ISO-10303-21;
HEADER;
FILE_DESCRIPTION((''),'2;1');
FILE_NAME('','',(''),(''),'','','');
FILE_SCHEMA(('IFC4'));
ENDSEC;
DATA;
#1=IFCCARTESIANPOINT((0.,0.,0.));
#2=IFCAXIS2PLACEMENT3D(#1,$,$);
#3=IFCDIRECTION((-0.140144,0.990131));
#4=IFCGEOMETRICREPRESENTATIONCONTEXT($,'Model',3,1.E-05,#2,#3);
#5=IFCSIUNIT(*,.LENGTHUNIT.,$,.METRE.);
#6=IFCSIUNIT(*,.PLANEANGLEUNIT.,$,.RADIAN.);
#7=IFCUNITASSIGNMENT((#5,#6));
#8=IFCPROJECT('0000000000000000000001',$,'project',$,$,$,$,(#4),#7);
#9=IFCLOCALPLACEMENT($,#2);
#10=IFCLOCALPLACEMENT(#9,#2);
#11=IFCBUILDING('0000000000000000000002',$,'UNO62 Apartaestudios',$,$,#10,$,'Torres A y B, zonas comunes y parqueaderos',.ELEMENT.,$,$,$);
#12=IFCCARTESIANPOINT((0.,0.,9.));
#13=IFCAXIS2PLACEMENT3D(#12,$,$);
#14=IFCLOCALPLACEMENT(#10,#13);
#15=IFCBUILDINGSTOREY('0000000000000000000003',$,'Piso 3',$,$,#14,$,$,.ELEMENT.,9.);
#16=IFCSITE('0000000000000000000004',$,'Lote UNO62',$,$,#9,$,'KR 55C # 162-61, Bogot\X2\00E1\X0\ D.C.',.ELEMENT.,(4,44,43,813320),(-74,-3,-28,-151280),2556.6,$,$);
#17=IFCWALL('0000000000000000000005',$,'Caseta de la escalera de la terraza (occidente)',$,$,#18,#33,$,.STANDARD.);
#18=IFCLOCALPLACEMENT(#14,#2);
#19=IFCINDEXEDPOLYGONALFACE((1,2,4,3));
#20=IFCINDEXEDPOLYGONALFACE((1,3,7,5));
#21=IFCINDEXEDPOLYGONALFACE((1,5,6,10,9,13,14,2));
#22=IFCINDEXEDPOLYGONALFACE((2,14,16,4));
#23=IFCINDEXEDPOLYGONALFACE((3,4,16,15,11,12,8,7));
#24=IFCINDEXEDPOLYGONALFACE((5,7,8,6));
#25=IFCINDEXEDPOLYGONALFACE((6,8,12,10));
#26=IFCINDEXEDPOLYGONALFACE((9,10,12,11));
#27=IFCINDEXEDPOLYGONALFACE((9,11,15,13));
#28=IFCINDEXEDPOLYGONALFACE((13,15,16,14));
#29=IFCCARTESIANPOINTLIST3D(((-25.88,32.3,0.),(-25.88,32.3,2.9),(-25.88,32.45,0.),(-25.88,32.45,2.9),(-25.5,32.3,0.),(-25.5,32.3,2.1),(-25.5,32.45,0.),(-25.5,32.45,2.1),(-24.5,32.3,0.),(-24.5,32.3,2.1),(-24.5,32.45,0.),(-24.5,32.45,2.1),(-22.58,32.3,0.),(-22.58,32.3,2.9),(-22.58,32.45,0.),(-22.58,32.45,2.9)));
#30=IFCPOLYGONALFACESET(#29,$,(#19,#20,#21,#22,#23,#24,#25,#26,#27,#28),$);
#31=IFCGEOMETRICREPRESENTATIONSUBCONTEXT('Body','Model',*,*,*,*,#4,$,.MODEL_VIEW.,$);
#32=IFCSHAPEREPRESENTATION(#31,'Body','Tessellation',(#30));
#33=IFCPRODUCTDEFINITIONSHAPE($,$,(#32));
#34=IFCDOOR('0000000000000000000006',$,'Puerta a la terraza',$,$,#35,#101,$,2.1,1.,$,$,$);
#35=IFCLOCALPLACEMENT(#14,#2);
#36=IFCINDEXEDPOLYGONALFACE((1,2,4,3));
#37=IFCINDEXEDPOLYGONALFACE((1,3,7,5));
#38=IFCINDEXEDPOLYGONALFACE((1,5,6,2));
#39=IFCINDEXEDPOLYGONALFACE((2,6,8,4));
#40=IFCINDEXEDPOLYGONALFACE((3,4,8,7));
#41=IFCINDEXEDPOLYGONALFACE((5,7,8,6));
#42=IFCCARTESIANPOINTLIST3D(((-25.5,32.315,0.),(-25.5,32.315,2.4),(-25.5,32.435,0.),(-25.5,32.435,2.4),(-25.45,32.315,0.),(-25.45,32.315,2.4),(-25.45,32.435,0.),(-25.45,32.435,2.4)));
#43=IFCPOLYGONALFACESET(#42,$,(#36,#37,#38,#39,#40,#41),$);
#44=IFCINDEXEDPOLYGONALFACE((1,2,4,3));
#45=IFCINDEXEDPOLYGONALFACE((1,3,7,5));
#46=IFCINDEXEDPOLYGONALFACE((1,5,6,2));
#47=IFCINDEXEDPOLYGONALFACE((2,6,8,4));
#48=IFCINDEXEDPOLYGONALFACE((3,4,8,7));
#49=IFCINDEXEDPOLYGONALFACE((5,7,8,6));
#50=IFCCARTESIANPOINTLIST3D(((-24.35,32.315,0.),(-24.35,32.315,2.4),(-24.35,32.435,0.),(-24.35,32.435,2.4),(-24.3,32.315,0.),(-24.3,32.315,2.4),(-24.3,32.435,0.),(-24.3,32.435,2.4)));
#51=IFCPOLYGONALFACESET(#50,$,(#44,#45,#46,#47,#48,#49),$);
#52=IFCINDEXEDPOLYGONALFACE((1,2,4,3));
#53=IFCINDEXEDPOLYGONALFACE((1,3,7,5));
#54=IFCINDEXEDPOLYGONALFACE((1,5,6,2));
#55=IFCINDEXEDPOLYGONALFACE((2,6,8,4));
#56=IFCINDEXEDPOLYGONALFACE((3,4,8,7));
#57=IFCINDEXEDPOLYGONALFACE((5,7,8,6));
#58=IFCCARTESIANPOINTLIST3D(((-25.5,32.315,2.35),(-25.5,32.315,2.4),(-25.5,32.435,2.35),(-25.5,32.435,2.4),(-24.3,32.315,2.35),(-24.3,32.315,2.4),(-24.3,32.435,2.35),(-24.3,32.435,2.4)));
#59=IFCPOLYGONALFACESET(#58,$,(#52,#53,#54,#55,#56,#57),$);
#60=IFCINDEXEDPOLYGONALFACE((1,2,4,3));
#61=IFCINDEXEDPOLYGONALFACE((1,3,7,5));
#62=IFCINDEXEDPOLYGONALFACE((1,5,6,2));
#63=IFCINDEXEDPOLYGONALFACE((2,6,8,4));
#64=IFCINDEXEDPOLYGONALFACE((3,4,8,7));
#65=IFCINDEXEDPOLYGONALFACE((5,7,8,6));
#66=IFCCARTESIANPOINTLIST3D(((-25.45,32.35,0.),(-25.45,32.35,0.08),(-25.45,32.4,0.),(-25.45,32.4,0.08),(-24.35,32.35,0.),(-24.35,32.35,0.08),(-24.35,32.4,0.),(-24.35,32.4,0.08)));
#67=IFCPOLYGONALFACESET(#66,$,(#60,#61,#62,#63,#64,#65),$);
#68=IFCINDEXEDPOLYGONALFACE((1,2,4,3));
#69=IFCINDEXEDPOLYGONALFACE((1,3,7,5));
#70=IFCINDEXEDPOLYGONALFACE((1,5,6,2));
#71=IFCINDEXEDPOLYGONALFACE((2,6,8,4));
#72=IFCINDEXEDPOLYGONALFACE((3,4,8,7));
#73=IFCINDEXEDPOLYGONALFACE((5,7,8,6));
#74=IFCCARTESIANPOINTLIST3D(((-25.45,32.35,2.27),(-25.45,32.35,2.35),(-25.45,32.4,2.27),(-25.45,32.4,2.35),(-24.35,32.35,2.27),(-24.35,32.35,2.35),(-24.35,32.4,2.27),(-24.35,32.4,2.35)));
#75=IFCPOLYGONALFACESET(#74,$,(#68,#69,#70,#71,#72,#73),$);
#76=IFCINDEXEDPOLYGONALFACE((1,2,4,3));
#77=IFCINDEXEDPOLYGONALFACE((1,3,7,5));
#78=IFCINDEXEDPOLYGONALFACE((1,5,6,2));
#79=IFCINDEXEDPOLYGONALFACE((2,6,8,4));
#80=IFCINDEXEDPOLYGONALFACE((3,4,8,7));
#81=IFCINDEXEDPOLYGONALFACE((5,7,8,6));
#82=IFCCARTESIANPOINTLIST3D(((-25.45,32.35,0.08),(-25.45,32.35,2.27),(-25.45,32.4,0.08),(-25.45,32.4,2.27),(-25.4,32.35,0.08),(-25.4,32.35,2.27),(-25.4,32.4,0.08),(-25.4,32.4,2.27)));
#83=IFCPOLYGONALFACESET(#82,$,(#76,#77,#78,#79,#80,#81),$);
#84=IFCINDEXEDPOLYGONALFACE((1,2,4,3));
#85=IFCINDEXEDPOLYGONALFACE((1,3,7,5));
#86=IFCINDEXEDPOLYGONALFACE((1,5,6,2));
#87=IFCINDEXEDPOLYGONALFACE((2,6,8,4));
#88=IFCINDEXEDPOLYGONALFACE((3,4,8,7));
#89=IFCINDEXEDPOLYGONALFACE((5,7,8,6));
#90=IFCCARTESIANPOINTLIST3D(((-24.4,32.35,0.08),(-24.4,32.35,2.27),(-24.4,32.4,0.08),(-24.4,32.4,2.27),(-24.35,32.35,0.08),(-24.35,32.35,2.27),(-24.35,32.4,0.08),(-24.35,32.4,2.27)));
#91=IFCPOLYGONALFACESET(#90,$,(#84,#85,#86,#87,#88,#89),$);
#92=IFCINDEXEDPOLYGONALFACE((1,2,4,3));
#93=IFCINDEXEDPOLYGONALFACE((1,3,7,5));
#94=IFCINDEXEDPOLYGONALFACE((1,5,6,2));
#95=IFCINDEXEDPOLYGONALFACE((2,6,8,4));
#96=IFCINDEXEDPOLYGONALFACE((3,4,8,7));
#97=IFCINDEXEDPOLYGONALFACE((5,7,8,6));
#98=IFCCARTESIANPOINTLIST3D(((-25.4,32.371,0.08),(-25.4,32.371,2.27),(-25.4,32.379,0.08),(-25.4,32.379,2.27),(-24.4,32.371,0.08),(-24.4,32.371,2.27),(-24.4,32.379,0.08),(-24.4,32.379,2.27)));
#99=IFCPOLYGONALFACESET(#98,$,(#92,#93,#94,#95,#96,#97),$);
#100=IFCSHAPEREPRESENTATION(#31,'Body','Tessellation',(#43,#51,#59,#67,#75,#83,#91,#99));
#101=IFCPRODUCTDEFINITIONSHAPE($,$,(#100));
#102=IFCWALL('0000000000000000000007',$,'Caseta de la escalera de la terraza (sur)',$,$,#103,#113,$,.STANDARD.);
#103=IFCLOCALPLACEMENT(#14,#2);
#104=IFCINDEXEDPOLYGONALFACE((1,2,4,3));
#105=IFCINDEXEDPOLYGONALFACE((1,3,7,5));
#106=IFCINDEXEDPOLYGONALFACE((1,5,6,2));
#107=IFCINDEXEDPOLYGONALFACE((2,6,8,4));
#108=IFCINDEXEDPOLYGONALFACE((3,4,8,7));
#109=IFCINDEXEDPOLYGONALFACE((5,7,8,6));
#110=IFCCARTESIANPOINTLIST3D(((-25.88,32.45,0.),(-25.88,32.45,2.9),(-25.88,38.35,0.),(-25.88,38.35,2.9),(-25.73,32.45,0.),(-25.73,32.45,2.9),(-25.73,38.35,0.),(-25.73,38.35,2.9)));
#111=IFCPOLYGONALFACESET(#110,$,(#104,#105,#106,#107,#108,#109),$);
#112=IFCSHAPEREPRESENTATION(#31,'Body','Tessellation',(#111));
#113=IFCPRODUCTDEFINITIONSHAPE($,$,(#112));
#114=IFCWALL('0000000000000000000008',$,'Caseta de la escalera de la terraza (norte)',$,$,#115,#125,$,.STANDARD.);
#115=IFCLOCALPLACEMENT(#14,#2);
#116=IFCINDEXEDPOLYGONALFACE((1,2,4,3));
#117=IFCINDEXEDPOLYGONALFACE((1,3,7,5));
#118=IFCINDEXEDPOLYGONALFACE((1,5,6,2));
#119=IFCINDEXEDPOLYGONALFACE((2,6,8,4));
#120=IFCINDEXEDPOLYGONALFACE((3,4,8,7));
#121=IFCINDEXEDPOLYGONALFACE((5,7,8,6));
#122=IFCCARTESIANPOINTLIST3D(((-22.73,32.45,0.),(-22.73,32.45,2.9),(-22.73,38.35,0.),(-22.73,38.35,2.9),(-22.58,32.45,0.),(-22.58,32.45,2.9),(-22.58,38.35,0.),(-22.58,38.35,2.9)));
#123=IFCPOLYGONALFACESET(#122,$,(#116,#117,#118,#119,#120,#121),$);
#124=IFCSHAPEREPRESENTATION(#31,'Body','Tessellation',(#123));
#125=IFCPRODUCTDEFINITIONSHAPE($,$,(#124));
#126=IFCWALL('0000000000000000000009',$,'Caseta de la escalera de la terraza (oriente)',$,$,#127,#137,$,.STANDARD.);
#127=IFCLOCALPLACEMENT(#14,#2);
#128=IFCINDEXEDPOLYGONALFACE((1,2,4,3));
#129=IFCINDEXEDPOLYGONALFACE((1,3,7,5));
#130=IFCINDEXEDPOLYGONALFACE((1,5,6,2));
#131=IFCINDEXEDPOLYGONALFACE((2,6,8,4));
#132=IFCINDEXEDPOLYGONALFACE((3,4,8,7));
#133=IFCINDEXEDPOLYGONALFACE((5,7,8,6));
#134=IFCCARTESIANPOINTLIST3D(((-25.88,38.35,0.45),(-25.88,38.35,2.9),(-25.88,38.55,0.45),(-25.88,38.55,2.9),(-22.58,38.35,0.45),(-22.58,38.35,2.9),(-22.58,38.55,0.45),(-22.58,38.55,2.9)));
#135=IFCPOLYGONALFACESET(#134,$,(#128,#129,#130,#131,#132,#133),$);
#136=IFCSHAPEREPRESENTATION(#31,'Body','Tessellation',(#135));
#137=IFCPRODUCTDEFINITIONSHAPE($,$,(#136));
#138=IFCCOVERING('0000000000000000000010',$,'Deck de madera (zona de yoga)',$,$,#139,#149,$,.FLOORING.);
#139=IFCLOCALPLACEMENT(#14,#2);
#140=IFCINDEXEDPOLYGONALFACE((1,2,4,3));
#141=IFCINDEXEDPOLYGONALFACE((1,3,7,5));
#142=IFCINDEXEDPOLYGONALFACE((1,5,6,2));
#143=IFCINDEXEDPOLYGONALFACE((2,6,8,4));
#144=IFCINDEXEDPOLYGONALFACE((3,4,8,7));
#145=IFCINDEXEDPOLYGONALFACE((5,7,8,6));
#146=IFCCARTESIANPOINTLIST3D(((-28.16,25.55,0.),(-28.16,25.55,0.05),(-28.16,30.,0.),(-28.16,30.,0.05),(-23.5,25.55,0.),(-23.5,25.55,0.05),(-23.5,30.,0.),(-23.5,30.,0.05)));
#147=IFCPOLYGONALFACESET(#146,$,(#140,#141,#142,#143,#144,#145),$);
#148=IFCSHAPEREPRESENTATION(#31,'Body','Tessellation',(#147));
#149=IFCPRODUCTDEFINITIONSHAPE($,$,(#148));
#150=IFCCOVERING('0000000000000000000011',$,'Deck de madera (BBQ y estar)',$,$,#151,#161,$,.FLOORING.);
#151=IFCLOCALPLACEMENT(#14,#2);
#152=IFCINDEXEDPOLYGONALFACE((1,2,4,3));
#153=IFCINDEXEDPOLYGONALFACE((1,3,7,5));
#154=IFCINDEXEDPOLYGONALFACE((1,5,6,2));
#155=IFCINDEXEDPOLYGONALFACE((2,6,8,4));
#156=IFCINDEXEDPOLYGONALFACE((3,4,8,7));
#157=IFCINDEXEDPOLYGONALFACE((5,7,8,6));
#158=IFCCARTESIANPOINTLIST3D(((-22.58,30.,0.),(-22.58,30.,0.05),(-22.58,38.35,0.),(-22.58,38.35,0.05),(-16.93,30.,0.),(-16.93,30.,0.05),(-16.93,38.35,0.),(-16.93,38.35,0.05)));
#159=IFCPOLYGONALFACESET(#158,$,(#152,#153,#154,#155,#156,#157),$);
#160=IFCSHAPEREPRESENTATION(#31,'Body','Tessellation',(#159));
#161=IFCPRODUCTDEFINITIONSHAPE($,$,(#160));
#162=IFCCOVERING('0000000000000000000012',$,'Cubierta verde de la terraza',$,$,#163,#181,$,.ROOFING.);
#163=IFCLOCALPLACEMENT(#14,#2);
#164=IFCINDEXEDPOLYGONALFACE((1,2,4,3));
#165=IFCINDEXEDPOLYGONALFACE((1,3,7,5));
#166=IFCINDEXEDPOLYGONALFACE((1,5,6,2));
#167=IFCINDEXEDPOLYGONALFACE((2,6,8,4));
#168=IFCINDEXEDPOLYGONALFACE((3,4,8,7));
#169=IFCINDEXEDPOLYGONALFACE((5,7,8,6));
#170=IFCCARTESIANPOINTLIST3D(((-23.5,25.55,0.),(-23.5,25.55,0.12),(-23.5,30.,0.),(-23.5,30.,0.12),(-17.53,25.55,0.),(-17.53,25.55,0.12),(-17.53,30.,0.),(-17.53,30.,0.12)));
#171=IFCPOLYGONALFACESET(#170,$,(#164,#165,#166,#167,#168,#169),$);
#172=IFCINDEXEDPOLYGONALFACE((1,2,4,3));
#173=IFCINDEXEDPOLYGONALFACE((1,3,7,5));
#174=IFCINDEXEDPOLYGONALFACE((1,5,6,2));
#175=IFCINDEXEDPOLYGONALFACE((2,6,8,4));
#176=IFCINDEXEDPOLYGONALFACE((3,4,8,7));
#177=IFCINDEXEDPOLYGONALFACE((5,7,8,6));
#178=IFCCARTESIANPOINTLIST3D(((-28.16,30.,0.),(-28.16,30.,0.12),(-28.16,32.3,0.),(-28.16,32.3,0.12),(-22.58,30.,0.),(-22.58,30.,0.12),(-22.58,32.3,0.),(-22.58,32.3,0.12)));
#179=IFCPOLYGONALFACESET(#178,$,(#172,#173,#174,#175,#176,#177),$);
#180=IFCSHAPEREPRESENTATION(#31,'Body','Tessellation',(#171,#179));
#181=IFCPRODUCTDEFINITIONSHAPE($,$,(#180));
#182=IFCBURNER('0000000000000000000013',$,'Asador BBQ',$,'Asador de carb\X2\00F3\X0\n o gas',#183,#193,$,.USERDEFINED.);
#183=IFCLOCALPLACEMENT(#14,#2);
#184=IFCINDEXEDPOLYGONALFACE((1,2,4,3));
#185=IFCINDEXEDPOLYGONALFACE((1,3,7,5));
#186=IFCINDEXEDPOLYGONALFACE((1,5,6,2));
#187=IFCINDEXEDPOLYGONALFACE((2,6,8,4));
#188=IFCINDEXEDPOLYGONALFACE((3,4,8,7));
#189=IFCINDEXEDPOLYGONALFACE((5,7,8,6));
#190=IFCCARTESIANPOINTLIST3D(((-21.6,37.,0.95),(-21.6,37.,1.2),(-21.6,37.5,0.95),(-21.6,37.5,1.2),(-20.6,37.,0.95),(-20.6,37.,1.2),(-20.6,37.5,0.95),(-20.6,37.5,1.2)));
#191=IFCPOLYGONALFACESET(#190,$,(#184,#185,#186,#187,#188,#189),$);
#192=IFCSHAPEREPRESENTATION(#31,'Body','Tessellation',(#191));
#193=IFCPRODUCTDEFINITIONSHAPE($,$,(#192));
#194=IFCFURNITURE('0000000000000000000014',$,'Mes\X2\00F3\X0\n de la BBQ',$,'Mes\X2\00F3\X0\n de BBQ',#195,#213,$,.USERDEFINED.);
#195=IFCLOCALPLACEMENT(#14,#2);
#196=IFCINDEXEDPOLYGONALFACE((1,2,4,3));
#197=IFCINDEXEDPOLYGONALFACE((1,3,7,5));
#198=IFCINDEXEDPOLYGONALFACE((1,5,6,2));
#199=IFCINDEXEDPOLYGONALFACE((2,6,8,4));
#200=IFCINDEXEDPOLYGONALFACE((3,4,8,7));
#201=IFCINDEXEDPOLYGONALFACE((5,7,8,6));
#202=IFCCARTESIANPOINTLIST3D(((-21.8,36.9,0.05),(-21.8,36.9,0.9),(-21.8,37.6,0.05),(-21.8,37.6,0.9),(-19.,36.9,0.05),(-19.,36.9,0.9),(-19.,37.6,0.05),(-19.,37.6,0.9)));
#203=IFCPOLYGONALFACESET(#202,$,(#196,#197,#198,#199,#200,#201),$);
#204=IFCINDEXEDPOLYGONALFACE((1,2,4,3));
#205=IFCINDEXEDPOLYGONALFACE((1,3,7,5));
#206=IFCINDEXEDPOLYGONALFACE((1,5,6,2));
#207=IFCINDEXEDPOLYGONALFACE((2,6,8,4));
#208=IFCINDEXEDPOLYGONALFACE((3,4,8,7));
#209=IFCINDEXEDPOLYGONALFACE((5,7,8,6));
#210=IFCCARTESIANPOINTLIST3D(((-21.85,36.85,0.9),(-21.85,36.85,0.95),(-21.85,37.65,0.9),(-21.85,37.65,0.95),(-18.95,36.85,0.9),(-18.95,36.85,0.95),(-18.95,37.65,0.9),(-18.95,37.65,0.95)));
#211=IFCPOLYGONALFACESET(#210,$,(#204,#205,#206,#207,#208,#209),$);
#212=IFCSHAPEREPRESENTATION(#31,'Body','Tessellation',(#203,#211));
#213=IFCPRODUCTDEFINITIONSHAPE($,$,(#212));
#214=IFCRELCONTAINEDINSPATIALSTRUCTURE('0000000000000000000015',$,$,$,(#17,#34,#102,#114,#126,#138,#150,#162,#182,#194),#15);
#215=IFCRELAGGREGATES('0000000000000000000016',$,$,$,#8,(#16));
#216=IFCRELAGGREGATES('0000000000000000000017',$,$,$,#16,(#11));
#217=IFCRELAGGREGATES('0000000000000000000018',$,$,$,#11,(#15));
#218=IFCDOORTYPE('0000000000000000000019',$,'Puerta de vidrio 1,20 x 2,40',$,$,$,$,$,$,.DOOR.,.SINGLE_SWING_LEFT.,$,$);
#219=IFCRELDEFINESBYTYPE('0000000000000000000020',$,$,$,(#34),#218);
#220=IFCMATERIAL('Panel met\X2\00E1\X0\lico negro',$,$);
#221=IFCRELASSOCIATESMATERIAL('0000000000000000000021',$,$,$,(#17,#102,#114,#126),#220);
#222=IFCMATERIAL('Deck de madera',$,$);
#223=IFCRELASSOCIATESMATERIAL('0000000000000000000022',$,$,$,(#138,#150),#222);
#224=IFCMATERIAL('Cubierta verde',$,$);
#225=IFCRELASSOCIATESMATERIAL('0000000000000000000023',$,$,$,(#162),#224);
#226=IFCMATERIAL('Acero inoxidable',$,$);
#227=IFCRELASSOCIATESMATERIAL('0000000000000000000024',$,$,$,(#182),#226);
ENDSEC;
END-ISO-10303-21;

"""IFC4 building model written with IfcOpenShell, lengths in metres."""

from ifc_helpers import new_model, si_unit, direction, frame, frame_2d, origin, place, context, subcontext, project, spatial, rectangle, extrude, source, transform, mapped, material, type_object, type_shapes, element, fill, save


model = new_model("IFC4")

# Units and contexts
model_context = context("Model", 3, precision=1e-05, world=origin(), true_north=direction((-0.140144, 0.990131)))
body_context = subcontext(model_context, "Body", "Model", "MODEL_VIEW")
ifc_project = project(units=[si_unit("LENGTHUNIT", "METRE"), si_unit("PLANEANGLEUNIT", "RADIAN")], contexts=[model_context])

# Site, building, storey
site_placement = place(None, origin())
site = spatial("IfcSite", under=ifc_project, at=site_placement, Name="Lote UNO62", LongName="KR 55C # 162-61, Bogotá D.C.", CompositionType="ELEMENT", RefLatitude=(4, 44, 43, 813320), RefLongitude=(-74, -3, -28, -151280), RefElevation=2556.6)
building_placement = place(site_placement, origin())
building = spatial("IfcBuilding", under=site, at=building_placement, Name="UNO62 Apartaestudios", LongName="Torres A y B, zonas comunes y parqueaderos", CompositionType="ELEMENT")
storey_placement = place(building_placement, frame((0.0, 0.0, 9.0)))
storey = spatial("IfcBuildingStorey", under=building, at=storey_placement, Name="Piso 3", CompositionType="ELEMENT", Elevation=9.0)

# Shared definitions
ifc_material_1 = material(Name="Panel metálico negro")

# Wall, opening, door
wall_1_placement = place(storey_placement, origin())
wall_1 = element("IfcWall", 1, at=wall_1_placement, inside=storey, material=ifc_material_1, Name="Caseta de la escalera de la terraza (occidente)", PredefinedType="STANDARD", context=body_context, shape_type="SweptSolid", body=[
    extrude(rectangle(XDim=3.3, YDim=0.15, at=frame_2d((-24.23, 32.375))), origin(), (0.0, 0.0, 1.0), 2.9),
])
opening_1_placement = place(wall_1_placement, origin())
opening_1 = element("IfcOpeningElement", 2, at=opening_1_placement, cuts=wall_1, PredefinedType="OPENING", context=body_context, shape_type="SweptSolid", body=[
    extrude(rectangle(XDim=1.0, YDim=0.25, at=frame_2d((-25.0, 32.375))), origin(), (0.0, 0.0, 1.0), 2.1),
])
door_type_1 = type_object("IfcDoorType", Name="Puerta de vidrio 1,20 x 2,40", OperationType="SINGLE_SWING_LEFT", PredefinedType="DOOR")
shared_shape_1 = source(origin(), body_context, "Body", "SweptSolid", [
    extrude(rectangle(XDim=0.05, YDim=0.12, at=frame_2d((0.025, 0.0))), origin(), (0.0, 0.0, 1.0), 2.4),
    extrude(rectangle(XDim=0.05, YDim=0.12, at=frame_2d((1.175, 0.0))), origin(), (0.0, 0.0, 1.0), 2.4),
    extrude(rectangle(XDim=1.2, YDim=0.12, at=frame_2d((0.6, 0.0))), frame((0.0, 0.0, 2.35)), (0.0, 0.0, 1.0), 0.05),
    extrude(rectangle(XDim=1.1, YDim=0.05, at=frame_2d((0.6, 0.0))), origin(), (0.0, 0.0, 1.0), 0.08),
    extrude(rectangle(XDim=1.1, YDim=0.05, at=frame_2d((0.6, 0.0))), frame((0.0, 0.0, 2.27)), (0.0, 0.0, 1.0), 0.08),
    extrude(rectangle(XDim=0.05, YDim=0.05, at=frame_2d((0.075, 0.0))), frame((0.0, 0.0, 0.08)), (0.0, 0.0, 1.0), 2.19),
    extrude(rectangle(XDim=0.05, YDim=0.05, at=frame_2d((1.125, 0.0))), frame((0.0, 0.0, 0.08)), (0.0, 0.0, 1.0), 2.19),
    extrude(rectangle(XDim=1.0, YDim=0.008, at=frame_2d((0.6, 0.0))), frame((0.0, 0.0, 0.08)), (0.0, 0.0, 1.0), 2.19),
])
type_shapes(door_type_1, [shared_shape_1])
door_1_placement = place(storey_placement, frame((-25.5, 32.375, 0.0), z_axis=(0.0, 0.0, 1.0), x_axis=(1.0, 0.0, 0.0)))
door_1 = element("IfcDoor", 3, at=door_1_placement, inside=storey, type_object=door_type_1, Name="Puerta a la terraza", OverallHeight=2.1, OverallWidth=1.0, context=body_context, shape_type="MappedRepresentation", body=[
    mapped(shared_shape_1, transform((0.0, 0.0, 0.0))),
])
fill(opening_1, door_1)

# Walls
wall_2_placement = place(storey_placement, origin())
element("IfcWall", 4, at=wall_2_placement, inside=storey, material=ifc_material_1, Name="Caseta de la escalera de la terraza (sur)", PredefinedType="STANDARD", context=body_context, shape_type="SweptSolid", body=[
    extrude(rectangle(XDim=0.15, YDim=5.9, at=frame_2d((-25.805, 35.4))), origin(), (0.0, 0.0, 1.0), 2.9),
])
wall_3_placement = place(storey_placement, origin())
element("IfcWall", 5, at=wall_3_placement, inside=storey, material=ifc_material_1, Name="Caseta de la escalera de la terraza (norte)", PredefinedType="STANDARD", context=body_context, shape_type="SweptSolid", body=[
    extrude(rectangle(XDim=0.15, YDim=5.9, at=frame_2d((-22.655, 35.4))), origin(), (0.0, 0.0, 1.0), 2.9),
])
wall_4_placement = place(storey_placement, origin())
element("IfcWall", 6, at=wall_4_placement, inside=storey, material=ifc_material_1, Name="Caseta de la escalera de la terraza (oriente)", PredefinedType="STANDARD", context=body_context, shape_type="SweptSolid", body=[
    extrude(rectangle(XDim=3.3, YDim=0.2, at=frame_2d((-24.23, 38.45))), frame((0.0, 0.0, 0.45)), (0.0, 0.0, 1.0), 2.45),
])

# Coverings
ifc_material_2 = material(Name="Deck de madera")
covering_1_placement = place(storey_placement, origin())
element("IfcCovering", 7, at=covering_1_placement, inside=storey, material=ifc_material_2, Name="Deck de madera (zona de yoga)", PredefinedType="FLOORING", context=body_context, shape_type="SweptSolid", body=[
    extrude(rectangle(XDim=4.66, YDim=4.45, at=frame_2d((-25.83, 27.775))), origin(), (0.0, 0.0, 1.0), 0.05),
])
covering_2_placement = place(storey_placement, origin())
element("IfcCovering", 8, at=covering_2_placement, inside=storey, material=ifc_material_2, Name="Deck de madera (BBQ y estar)", PredefinedType="FLOORING", context=body_context, shape_type="SweptSolid", body=[
    extrude(rectangle(XDim=5.65, YDim=8.35, at=frame_2d((-19.755, 34.175))), origin(), (0.0, 0.0, 1.0), 0.05),
])
ifc_material_3 = material(Name="Cubierta verde")
covering_3_placement = place(storey_placement, origin())
element("IfcCovering", 9, at=covering_3_placement, inside=storey, material=ifc_material_3, Name="Cubierta verde de la terraza", PredefinedType="ROOFING", context=body_context, shape_type="SweptSolid", body=[
    extrude(rectangle(XDim=5.97, YDim=4.45, at=frame_2d((-20.515, 27.775))), origin(), (0.0, 0.0, 1.0), 0.12),
    extrude(rectangle(XDim=5.58, YDim=2.3, at=frame_2d((-25.37, 31.15))), origin(), (0.0, 0.0, 1.0), 0.12),
])

# Burner
ifc_material_4 = material(Name="Acero inoxidable")
burner_placement = place(storey_placement, origin())
element("IfcBurner", 10, at=burner_placement, inside=storey, material=ifc_material_4, Name="Asador BBQ", ObjectType="Asador de carbón o gas", PredefinedType="USERDEFINED", context=body_context, shape_type="SweptSolid", body=[
    extrude(rectangle(XDim=1.0, YDim=0.5, at=frame_2d((-21.1, 37.25))), frame((0.0, 0.0, 0.95)), (0.0, 0.0, 1.0), 0.25),
])

# Furniture
furniture_1_placement = place(storey_placement, origin())
element("IfcFurniture", 11, at=furniture_1_placement, inside=storey, Name="Mesón de la BBQ", ObjectType="Mesón de BBQ", PredefinedType="USERDEFINED", context=body_context, shape_type="SweptSolid", body=[
    extrude(rectangle(XDim=2.8, YDim=0.7, at=frame_2d((-20.4, 37.25))), frame((0.0, 0.0, 0.05)), (0.0, 0.0, 1.0), 0.85),
    extrude(rectangle(XDim=2.9, YDim=0.8, at=frame_2d((-20.4, 37.25))), frame((0.0, 0.0, 0.9)), (0.0, 0.0, 1.0), 0.05),
])

save(model, "model.ifc")
